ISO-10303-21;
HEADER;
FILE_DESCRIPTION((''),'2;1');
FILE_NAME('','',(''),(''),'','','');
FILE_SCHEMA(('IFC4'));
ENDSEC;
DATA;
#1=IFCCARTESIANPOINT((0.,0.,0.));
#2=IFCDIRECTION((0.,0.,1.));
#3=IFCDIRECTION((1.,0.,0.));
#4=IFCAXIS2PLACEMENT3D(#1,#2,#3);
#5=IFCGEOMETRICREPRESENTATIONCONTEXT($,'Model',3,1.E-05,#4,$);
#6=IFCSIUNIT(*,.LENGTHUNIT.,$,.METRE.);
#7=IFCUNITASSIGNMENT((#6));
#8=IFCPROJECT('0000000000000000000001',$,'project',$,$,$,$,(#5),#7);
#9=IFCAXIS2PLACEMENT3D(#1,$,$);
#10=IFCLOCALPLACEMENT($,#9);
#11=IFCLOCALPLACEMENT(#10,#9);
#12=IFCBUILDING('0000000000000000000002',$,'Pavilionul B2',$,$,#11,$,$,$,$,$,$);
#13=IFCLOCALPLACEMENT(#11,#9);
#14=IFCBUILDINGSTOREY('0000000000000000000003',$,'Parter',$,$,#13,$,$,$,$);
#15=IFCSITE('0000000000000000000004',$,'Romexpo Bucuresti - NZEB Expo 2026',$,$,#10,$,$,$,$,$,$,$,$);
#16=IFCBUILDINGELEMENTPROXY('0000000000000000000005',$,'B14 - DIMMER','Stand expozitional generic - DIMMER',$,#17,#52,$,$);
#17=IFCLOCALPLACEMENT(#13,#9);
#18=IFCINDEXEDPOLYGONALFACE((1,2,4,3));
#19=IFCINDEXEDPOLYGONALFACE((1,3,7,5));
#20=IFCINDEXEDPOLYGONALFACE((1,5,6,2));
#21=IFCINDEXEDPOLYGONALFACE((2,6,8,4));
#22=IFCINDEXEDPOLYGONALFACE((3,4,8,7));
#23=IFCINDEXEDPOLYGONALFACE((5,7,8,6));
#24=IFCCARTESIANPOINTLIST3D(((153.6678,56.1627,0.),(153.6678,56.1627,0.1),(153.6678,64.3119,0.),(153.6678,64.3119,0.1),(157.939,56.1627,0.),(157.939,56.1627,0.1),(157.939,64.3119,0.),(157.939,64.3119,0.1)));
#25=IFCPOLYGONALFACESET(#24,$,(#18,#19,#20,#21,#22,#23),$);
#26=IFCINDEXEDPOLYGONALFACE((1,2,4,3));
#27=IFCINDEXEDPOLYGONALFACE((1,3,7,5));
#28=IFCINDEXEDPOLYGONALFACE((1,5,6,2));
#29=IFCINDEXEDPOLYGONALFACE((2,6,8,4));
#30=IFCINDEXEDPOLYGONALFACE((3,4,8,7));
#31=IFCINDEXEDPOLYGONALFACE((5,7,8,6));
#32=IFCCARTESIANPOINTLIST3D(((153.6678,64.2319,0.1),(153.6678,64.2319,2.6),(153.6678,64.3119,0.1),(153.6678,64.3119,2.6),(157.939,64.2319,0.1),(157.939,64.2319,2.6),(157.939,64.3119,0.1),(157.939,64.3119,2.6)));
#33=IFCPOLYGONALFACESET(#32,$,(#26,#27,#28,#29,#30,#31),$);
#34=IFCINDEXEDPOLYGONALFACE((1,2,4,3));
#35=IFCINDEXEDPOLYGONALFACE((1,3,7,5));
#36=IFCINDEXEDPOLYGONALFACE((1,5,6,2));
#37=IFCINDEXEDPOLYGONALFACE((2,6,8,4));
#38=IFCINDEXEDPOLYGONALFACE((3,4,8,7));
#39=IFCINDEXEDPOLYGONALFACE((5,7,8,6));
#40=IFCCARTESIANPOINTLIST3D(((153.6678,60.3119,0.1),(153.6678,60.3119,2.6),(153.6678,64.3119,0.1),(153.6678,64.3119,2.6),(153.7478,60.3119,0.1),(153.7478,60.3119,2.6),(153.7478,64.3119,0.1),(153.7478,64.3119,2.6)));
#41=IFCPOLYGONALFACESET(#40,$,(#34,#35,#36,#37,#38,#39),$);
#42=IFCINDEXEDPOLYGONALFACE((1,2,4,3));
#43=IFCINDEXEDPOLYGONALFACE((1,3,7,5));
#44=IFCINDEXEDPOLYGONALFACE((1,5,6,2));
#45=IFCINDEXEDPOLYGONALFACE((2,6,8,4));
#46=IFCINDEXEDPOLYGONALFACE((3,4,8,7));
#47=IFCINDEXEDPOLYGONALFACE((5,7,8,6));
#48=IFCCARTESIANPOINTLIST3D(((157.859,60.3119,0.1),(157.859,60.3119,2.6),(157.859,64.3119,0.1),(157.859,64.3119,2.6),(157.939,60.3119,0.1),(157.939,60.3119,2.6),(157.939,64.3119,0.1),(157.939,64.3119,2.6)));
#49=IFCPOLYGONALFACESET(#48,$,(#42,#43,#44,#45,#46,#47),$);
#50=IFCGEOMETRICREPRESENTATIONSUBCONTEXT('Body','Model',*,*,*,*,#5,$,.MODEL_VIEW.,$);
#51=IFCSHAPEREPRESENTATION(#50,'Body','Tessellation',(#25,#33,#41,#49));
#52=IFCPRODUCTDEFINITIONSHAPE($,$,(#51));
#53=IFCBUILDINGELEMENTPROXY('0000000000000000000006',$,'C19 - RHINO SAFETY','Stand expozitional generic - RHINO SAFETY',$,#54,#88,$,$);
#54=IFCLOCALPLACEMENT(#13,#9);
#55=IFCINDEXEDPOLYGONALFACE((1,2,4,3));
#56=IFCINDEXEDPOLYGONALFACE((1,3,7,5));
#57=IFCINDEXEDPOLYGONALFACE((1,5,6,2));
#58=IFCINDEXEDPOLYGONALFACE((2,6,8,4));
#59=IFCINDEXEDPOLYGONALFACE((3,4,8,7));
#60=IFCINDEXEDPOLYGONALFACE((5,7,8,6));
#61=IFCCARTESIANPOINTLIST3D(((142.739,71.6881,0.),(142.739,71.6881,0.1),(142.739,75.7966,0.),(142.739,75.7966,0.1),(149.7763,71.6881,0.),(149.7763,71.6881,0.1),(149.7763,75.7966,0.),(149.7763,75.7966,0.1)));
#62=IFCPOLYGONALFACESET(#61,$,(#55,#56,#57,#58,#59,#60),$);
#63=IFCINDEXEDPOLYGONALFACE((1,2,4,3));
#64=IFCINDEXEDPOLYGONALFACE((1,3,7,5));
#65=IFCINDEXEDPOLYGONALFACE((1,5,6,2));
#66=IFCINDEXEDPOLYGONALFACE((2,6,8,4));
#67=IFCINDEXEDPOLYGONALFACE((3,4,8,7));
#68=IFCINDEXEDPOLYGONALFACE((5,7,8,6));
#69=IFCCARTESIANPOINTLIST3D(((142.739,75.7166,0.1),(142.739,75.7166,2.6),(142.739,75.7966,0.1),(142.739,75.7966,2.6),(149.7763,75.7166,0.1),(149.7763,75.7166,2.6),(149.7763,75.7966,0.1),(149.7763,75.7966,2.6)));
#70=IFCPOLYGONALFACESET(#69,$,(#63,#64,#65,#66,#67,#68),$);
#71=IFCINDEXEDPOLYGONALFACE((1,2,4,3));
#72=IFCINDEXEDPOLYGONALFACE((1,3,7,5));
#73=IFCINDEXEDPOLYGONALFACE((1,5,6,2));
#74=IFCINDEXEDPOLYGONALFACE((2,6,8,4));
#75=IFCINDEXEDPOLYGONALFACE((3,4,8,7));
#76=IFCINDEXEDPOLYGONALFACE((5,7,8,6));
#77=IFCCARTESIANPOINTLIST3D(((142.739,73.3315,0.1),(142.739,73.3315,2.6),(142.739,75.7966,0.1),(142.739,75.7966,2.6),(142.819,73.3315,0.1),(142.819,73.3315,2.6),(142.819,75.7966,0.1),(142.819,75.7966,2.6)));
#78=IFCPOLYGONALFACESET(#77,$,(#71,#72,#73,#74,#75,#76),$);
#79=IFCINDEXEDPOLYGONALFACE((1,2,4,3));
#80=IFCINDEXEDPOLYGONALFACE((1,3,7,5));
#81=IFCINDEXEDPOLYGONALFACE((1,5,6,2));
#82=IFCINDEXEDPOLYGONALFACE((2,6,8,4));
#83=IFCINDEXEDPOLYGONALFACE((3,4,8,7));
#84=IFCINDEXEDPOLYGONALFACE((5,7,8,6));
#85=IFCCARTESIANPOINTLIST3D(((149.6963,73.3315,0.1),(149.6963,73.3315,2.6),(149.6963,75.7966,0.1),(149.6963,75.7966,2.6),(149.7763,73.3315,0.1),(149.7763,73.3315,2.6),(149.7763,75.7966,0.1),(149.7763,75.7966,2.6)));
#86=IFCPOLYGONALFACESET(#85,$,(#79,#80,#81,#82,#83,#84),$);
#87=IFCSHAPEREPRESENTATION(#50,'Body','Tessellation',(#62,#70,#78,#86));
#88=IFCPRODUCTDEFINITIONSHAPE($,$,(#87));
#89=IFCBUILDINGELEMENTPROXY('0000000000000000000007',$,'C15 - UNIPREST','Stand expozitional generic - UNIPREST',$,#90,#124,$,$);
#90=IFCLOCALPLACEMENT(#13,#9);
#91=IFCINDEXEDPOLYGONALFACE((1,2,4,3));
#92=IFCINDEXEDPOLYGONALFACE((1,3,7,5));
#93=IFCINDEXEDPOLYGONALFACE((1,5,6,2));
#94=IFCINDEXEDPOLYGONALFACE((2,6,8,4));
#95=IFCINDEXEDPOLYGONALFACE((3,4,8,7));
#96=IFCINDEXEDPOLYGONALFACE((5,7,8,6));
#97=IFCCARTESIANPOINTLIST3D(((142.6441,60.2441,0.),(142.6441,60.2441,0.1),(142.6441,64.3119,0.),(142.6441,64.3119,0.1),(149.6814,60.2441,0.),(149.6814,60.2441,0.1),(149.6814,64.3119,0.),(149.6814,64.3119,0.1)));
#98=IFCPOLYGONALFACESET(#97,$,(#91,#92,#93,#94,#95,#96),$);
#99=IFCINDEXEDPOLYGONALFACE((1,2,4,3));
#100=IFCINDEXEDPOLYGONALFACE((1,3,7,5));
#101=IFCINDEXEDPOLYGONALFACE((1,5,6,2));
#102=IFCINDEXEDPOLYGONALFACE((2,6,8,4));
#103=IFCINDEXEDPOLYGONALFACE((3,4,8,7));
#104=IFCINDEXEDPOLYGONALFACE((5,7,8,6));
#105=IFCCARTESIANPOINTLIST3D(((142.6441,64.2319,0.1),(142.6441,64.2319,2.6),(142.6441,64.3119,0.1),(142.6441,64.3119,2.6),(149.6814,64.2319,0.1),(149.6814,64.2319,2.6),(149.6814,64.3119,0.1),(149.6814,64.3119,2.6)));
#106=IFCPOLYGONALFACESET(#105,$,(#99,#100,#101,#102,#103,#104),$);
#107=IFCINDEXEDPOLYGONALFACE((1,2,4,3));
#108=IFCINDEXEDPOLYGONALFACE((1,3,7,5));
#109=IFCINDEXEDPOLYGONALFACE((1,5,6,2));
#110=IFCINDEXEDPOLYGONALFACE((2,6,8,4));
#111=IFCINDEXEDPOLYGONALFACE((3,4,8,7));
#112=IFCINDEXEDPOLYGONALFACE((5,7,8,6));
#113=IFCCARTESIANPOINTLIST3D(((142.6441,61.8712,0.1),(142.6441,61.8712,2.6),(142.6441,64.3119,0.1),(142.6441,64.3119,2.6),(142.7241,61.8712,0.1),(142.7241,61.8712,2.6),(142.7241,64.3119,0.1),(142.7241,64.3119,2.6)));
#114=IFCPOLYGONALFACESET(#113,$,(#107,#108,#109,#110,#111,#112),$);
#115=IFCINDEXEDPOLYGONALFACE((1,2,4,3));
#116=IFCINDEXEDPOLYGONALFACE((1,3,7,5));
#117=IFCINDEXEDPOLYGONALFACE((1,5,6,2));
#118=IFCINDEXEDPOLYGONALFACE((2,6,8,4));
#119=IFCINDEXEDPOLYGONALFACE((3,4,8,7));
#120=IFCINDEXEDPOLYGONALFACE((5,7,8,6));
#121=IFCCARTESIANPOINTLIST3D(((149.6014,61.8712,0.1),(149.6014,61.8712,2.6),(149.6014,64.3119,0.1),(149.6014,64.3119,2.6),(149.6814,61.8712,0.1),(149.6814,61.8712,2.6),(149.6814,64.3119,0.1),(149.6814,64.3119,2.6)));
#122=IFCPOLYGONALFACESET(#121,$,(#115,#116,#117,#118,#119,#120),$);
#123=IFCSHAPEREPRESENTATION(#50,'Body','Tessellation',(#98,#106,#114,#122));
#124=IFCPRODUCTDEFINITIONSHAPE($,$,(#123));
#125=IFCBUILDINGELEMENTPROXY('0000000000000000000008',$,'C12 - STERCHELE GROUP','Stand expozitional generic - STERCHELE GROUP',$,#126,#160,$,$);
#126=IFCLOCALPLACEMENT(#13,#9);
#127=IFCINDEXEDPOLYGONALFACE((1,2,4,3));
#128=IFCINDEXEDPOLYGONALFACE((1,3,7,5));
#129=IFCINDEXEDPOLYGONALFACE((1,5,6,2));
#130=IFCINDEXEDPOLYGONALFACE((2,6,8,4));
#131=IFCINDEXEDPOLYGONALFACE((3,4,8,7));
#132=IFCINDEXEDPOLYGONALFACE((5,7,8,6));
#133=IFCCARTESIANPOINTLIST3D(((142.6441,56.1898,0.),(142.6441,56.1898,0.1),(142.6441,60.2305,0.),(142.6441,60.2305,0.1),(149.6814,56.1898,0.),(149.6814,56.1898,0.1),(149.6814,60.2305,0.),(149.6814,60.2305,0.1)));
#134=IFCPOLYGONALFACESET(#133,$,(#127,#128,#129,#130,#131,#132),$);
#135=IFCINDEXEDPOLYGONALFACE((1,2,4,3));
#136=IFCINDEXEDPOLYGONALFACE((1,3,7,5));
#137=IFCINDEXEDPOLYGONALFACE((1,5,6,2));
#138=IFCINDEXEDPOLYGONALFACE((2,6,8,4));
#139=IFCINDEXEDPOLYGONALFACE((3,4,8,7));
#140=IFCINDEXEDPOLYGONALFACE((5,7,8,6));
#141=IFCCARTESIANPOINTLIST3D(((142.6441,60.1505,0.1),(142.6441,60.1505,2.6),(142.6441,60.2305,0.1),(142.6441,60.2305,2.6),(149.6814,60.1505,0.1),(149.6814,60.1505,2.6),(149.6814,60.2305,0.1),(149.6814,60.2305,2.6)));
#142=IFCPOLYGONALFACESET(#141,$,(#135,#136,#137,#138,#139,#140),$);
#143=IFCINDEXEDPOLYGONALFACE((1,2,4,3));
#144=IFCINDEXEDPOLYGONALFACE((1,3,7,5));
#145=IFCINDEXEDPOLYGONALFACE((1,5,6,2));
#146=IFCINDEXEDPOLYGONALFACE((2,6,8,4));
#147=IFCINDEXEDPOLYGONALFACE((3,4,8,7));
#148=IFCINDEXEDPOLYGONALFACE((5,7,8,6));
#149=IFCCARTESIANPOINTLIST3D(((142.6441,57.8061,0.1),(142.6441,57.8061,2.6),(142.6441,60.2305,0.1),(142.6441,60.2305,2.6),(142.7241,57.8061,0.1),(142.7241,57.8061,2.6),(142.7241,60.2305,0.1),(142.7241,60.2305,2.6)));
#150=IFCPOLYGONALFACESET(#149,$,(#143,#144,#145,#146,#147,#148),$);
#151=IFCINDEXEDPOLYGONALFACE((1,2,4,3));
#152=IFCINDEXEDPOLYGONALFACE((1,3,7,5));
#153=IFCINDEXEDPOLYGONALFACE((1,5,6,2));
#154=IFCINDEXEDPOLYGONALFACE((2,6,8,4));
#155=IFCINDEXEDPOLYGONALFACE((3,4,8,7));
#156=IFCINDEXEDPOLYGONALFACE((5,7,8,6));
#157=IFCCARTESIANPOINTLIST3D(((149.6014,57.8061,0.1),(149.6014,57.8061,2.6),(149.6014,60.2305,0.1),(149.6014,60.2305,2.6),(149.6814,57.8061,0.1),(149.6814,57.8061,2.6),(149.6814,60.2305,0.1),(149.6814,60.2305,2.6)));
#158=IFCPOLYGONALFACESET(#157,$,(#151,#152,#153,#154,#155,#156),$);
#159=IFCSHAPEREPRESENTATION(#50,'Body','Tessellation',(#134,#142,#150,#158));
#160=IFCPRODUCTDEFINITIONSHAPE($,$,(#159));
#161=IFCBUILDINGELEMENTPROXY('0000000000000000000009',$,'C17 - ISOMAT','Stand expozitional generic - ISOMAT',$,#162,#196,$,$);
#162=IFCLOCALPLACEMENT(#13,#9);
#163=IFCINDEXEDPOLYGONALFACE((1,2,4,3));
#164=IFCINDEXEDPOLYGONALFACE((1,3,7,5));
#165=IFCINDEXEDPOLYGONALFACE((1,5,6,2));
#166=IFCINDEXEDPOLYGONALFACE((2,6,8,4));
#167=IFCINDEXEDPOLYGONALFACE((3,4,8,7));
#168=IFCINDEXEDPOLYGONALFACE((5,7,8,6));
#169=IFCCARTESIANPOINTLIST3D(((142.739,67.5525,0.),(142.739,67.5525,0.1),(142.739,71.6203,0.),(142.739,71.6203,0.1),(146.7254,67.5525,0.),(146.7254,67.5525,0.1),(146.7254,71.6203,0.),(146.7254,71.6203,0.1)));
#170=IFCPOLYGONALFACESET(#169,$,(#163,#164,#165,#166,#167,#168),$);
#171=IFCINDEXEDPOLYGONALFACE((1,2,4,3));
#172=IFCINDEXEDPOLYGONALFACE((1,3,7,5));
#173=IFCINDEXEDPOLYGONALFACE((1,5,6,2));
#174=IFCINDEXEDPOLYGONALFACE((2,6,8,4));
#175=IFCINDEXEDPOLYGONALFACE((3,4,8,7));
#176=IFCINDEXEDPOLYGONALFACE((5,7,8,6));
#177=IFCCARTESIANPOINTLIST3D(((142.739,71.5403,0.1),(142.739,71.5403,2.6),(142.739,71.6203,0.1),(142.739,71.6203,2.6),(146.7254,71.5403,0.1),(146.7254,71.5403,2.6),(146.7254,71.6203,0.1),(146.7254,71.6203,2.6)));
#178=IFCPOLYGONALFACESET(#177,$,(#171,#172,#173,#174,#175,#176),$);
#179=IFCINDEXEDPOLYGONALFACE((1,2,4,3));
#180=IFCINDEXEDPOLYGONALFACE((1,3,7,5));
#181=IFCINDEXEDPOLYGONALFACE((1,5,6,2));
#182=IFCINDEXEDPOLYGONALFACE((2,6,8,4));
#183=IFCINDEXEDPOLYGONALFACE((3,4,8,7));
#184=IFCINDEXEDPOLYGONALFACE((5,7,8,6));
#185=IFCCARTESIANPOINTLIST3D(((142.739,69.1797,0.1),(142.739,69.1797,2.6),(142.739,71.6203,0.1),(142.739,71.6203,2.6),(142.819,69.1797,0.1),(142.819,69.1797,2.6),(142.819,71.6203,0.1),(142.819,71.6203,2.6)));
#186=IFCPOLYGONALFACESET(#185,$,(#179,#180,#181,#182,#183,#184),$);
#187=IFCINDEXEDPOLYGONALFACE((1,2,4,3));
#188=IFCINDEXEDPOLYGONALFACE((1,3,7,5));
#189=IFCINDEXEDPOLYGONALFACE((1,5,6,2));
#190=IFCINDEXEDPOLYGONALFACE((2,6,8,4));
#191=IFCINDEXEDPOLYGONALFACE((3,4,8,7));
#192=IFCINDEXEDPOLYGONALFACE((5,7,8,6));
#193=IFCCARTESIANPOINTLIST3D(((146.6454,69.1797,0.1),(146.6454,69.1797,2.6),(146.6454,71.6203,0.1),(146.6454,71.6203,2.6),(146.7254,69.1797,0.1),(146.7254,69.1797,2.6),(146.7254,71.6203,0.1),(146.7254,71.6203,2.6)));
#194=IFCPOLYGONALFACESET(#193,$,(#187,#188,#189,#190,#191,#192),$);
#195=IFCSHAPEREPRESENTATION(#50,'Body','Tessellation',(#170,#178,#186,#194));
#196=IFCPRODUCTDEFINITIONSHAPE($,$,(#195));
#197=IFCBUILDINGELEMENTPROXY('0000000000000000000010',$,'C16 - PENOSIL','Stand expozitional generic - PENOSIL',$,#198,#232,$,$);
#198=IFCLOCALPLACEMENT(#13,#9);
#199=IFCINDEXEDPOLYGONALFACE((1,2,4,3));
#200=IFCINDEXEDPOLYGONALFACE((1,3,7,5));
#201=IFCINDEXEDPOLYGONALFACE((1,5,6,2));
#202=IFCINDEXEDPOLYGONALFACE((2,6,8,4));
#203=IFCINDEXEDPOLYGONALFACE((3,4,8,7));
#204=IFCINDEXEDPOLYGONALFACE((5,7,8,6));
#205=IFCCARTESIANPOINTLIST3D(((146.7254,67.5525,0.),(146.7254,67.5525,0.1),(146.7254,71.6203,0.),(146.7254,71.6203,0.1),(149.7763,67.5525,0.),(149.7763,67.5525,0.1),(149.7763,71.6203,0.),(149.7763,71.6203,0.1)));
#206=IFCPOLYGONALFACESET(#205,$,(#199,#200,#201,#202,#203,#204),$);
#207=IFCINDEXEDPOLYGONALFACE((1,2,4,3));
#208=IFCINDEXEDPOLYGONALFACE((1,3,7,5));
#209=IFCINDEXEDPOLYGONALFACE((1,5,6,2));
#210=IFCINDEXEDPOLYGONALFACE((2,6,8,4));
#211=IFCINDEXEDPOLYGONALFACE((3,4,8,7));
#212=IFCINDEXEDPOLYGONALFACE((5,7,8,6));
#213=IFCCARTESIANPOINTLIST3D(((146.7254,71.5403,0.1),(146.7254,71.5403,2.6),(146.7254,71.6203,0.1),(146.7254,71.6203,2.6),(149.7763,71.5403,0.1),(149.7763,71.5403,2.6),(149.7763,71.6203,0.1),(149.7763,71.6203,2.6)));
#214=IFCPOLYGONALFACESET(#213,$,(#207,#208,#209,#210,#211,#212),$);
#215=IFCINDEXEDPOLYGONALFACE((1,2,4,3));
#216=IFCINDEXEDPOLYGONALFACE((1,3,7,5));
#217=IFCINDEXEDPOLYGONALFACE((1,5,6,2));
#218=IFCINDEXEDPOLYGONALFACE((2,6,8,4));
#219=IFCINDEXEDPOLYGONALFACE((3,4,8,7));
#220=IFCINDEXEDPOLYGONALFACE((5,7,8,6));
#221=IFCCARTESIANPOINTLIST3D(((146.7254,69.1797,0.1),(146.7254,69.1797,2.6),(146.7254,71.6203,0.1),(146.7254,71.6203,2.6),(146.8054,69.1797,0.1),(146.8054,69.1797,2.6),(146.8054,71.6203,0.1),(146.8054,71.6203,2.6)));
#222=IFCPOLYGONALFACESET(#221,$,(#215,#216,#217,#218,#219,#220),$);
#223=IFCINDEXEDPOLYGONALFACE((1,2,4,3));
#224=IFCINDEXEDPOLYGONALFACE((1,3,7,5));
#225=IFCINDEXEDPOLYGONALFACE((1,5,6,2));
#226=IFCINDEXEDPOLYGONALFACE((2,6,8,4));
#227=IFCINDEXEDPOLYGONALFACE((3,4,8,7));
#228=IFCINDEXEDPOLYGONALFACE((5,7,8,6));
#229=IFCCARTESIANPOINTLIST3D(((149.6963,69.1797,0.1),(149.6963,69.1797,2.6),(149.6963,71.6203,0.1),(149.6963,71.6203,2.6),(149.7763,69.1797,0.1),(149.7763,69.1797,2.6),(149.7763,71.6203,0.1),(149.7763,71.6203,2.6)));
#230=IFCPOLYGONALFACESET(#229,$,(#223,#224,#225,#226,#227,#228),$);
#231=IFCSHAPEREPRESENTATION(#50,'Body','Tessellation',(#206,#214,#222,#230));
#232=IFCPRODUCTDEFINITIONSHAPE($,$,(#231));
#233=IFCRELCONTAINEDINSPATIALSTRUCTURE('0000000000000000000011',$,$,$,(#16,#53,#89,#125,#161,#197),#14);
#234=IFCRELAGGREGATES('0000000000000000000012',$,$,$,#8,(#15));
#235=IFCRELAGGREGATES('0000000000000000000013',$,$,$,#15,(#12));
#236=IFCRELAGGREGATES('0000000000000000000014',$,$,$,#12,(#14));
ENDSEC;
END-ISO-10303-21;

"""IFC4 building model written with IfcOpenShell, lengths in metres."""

from ifc_helpers import new_model, si_unit, frame, frame_2d, origin, origin_with_axes, place, context, subcontext, project, spatial, rectangle, extrude, element, save


model = new_model("IFC4")

# Units and contexts
model_context = context("Model", 3, precision=1e-05, world=origin_with_axes())
body_context = subcontext(model_context, "Body", "Model", "MODEL_VIEW")
ifc_project = project(units=[si_unit("LENGTHUNIT", "METRE")], contexts=[model_context])

# Site, building, storey
site_placement = place(None, origin())
site = spatial("IfcSite", under=ifc_project, at=site_placement, Name="Romexpo Bucuresti - NZEB Expo 2026")
building_placement = place(site_placement, origin())
building = spatial("IfcBuilding", under=site, at=building_placement, Name="Pavilionul B2")
storey_placement = place(building_placement, origin())
storey = spatial("IfcBuildingStorey", under=building, at=storey_placement, Name="Parter")

# Building element proxies
proxy_1_placement = place(storey_placement, frame((153.6678, 56.1627, 0.0), z_axis=(0.0, 0.0, 1.0), x_axis=(1.0, 0.0, 0.0)))
element("IfcBuildingElementProxy", 1, at=proxy_1_placement, inside=storey, Name="B14 - DIMMER", Description="Stand expozitional generic - DIMMER", context=body_context, shape_type="SweptSolid", body=[
    extrude(rectangle(XDim=4.2712, YDim=8.1492, at=frame_2d((2.1356, 4.0746))), origin(), (0.0, 0.0, 1.0), 0.1),
    extrude(rectangle(XDim=4.2712, YDim=0.08, at=frame_2d((2.1356, 8.1092))), frame((0.0, 0.0, 0.1)), (0.0, 0.0, 1.0), 2.5),
    extrude(rectangle(XDim=0.08, YDim=4.0, at=frame_2d((0.04, 6.1492))), frame((0.0, 0.0, 0.1)), (0.0, 0.0, 1.0), 2.5),
    extrude(rectangle(XDim=0.08, YDim=4.0, at=frame_2d((4.2312, 6.1492))), frame((0.0, 0.0, 0.1)), (0.0, 0.0, 1.0), 2.5),
])
proxy_2_placement = place(storey_placement, frame((142.739, 71.6881, 0.0), z_axis=(0.0, 0.0, 1.0), x_axis=(1.0, 0.0, 0.0)))
element("IfcBuildingElementProxy", 2, at=proxy_2_placement, inside=storey, Name="C19 - RHINO SAFETY", Description="Stand expozitional generic - RHINO SAFETY", context=body_context, shape_type="SweptSolid", body=[
    extrude(rectangle(XDim=7.0373, YDim=4.1085, at=frame_2d((3.5186, 2.0542))), origin(), (0.0, 0.0, 1.0), 0.1),
    extrude(rectangle(XDim=7.0373, YDim=0.08, at=frame_2d((3.5186, 4.0685))), frame((0.0, 0.0, 0.1)), (0.0, 0.0, 1.0), 2.5),
    extrude(rectangle(XDim=0.08, YDim=2.4651, at=frame_2d((0.04, 2.8759))), frame((0.0, 0.0, 0.1)), (0.0, 0.0, 1.0), 2.5),
    extrude(rectangle(XDim=0.08, YDim=2.4651, at=frame_2d((6.9973, 2.8759))), frame((0.0, 0.0, 0.1)), (0.0, 0.0, 1.0), 2.5),
])
proxy_3_placement = place(storey_placement, frame((142.6441, 60.2441, 0.0), z_axis=(0.0, 0.0, 1.0), x_axis=(1.0, 0.0, 0.0)))
element("IfcBuildingElementProxy", 3, at=proxy_3_placement, inside=storey, Name="C15 - UNIPREST", Description="Stand expozitional generic - UNIPREST", context=body_context, shape_type="SweptSolid", body=[
    extrude(rectangle(XDim=7.0373, YDim=4.0678, at=frame_2d((3.5186, 2.0339))), origin(), (0.0, 0.0, 1.0), 0.1),
    extrude(rectangle(XDim=7.0373, YDim=0.08, at=frame_2d((3.5186, 4.0278))), frame((0.0, 0.0, 0.1)), (0.0, 0.0, 1.0), 2.5),
    extrude(rectangle(XDim=0.08, YDim=2.4407, at=frame_2d((0.04, 2.8475))), frame((0.0, 0.0, 0.1)), (0.0, 0.0, 1.0), 2.5),
    extrude(rectangle(XDim=0.08, YDim=2.4407, at=frame_2d((6.9973, 2.8475))), frame((0.0, 0.0, 0.1)), (0.0, 0.0, 1.0), 2.5),
])
proxy_4_placement = place(storey_placement, frame((142.6441, 56.1898, 0.0), z_axis=(0.0, 0.0, 1.0), x_axis=(1.0, 0.0, 0.0)))
element("IfcBuildingElementProxy", 4, at=proxy_4_placement, inside=storey, Name="C12 - STERCHELE GROUP", Description="Stand expozitional generic - STERCHELE GROUP", context=body_context, shape_type="SweptSolid", body=[
    extrude(rectangle(XDim=7.0373, YDim=4.0407, at=frame_2d((3.5186, 2.0203))), origin(), (0.0, 0.0, 1.0), 0.1),
    extrude(rectangle(XDim=7.0373, YDim=0.08, at=frame_2d((3.5186, 4.0007))), frame((0.0, 0.0, 0.1)), (0.0, 0.0, 1.0), 2.5),
    extrude(rectangle(XDim=0.08, YDim=2.4244, at=frame_2d((0.04, 2.8285))), frame((0.0, 0.0, 0.1)), (0.0, 0.0, 1.0), 2.5),
    extrude(rectangle(XDim=0.08, YDim=2.4244, at=frame_2d((6.9973, 2.8285))), frame((0.0, 0.0, 0.1)), (0.0, 0.0, 1.0), 2.5),
])
proxy_5_placement = place(storey_placement, frame((142.739, 67.5525, 0.0), z_axis=(0.0, 0.0, 1.0), x_axis=(1.0, 0.0, 0.0)))
element("IfcBuildingElementProxy", 5, at=proxy_5_placement, inside=storey, Name="C17 - ISOMAT", Description="Stand expozitional generic - ISOMAT", context=body_context, shape_type="SweptSolid", body=[
    extrude(rectangle(XDim=3.9864, YDim=4.0678, at=frame_2d((1.9932, 2.0339))), origin(), (0.0, 0.0, 1.0), 0.1),
    extrude(rectangle(XDim=3.9864, YDim=0.08, at=frame_2d((1.9932, 4.0278))), frame((0.0, 0.0, 0.1)), (0.0, 0.0, 1.0), 2.5),
    extrude(rectangle(XDim=0.08, YDim=2.4407, at=frame_2d((0.04, 2.8475))), frame((0.0, 0.0, 0.1)), (0.0, 0.0, 1.0), 2.5),
    extrude(rectangle(XDim=0.08, YDim=2.4407, at=frame_2d((3.9464, 2.8475))), frame((0.0, 0.0, 0.1)), (0.0, 0.0, 1.0), 2.5),
])
proxy_6_placement = place(storey_placement, frame((146.7254, 67.5525, 0.0), z_axis=(0.0, 0.0, 1.0), x_axis=(1.0, 0.0, 0.0)))
element("IfcBuildingElementProxy", 6, at=proxy_6_placement, inside=storey, Name="C16 - PENOSIL", Description="Stand expozitional generic - PENOSIL", context=body_context, shape_type="SweptSolid", body=[
    extrude(rectangle(XDim=3.0508, YDim=4.0678, at=frame_2d((1.5254, 2.0339))), origin(), (0.0, 0.0, 1.0), 0.1),
    extrude(rectangle(XDim=3.0508, YDim=0.08, at=frame_2d((1.5254, 4.0278))), frame((0.0, 0.0, 0.1)), (0.0, 0.0, 1.0), 2.5),
    extrude(rectangle(XDim=0.08, YDim=2.4407, at=frame_2d((0.04, 2.8475))), frame((0.0, 0.0, 0.1)), (0.0, 0.0, 1.0), 2.5),
    extrude(rectangle(XDim=0.08, YDim=2.4407, at=frame_2d((3.0108, 2.8475))), frame((0.0, 0.0, 0.1)), (0.0, 0.0, 1.0), 2.5),
])

save(model, "model.ifc")
